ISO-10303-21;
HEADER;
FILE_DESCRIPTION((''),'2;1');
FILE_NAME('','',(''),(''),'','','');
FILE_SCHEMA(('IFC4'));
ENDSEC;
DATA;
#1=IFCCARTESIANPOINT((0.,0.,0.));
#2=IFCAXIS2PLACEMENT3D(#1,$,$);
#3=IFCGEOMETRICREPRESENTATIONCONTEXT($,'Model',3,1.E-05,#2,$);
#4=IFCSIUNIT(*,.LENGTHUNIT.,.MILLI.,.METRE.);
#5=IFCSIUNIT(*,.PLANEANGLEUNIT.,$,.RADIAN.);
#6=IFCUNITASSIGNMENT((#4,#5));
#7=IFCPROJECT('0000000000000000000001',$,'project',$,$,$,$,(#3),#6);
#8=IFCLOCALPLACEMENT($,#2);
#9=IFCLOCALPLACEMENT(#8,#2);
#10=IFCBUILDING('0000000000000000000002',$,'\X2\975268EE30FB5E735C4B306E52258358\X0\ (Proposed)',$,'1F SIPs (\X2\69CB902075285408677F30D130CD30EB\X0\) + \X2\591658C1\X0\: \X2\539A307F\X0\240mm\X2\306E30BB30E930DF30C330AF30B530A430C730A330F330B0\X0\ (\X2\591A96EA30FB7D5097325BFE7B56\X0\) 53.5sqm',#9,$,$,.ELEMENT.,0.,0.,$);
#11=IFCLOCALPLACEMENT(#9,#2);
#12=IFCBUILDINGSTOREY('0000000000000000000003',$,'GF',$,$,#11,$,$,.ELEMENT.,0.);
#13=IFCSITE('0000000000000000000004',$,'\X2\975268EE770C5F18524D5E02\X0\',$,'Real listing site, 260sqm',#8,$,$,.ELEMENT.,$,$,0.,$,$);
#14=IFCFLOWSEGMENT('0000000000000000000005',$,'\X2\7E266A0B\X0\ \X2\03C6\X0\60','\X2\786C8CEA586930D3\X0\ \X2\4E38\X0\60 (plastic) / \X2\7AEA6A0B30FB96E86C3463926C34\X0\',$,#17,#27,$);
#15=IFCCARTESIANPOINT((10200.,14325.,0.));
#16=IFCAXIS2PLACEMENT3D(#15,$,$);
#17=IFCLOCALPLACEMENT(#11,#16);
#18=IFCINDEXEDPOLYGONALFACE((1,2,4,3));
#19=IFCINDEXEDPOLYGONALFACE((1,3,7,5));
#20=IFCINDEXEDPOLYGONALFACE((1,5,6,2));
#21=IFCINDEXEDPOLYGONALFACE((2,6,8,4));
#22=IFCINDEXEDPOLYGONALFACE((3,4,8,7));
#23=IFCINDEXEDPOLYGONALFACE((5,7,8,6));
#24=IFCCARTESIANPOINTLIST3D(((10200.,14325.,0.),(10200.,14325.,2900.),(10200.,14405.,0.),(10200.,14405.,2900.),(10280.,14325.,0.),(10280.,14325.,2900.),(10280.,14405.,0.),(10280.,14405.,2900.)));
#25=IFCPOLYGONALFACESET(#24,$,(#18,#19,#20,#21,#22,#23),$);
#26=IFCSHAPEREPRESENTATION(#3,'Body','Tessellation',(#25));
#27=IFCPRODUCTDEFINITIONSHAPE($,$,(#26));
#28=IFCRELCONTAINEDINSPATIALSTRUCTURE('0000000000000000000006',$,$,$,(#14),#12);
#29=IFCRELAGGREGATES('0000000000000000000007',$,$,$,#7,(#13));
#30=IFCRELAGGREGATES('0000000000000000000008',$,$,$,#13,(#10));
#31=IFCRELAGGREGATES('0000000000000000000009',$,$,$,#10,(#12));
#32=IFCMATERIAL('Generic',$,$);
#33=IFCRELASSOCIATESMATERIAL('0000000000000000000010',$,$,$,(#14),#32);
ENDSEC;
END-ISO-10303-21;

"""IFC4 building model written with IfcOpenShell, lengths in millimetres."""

from ifc_helpers import new_model, si_unit, frame, frame_2d, origin, place, context, project, spatial, rectangle, extrude, material, element, save


model = new_model("IFC4")

# Units and contexts
model_context = context("Model", 3, precision=1e-05, world=origin())
ifc_project = project(units=[si_unit("LENGTHUNIT", "METRE", prefix="MILLI"), si_unit("PLANEANGLEUNIT", "RADIAN")], contexts=[model_context])

# Site, building, storey
site_placement = place(None, origin())
site = spatial("IfcSite", under=ifc_project, at=site_placement, Name="青森県弘前市", ObjectType="Real listing site, 260sqm", CompositionType="ELEMENT", RefElevation=0.0)
building_placement = place(site_placement, origin())
building = spatial("IfcBuilding", under=site, at=building_placement, Name="青森・平屋の別荘 (Proposed)", ObjectType="1F SIPs (構造用合板パネル) + 外壁: 厚み240mmのセラミックサイディング (多雪・結露対策) 53.5sqm", CompositionType="ELEMENT", ElevationOfRefHeight=0.0, ElevationOfTerrain=0.0)
storey_placement = place(building_placement, origin())
storey = spatial("IfcBuildingStorey", under=building, at=storey_placement, Name="GF", CompositionType="ELEMENT", Elevation=0.0)

# Shared definitions
ifc_material_1 = material(Name="Generic")

# Flow segment
flow_segment_placement = place(storey_placement, frame((10200.0, 14325.0, 0.0)))
element("IfcFlowSegment", 1, at=flow_segment_placement, inside=storey, material=ifc_material_1, Name="縦樋 φ60", Description="硬質塩ビ 丸60 (plastic) / 竪樋・雨水排水", context=model_context, shape_type="SweptSolid", body=[
    extrude(rectangle(XDim=80.0, YDim=80.0, at=frame_2d((40.0, 40.0))), frame((10200.0, 14325.0, 0.0)), (0.0, 0.0, 1.0), 2900.0),
])

save(model, "model.ifc")
